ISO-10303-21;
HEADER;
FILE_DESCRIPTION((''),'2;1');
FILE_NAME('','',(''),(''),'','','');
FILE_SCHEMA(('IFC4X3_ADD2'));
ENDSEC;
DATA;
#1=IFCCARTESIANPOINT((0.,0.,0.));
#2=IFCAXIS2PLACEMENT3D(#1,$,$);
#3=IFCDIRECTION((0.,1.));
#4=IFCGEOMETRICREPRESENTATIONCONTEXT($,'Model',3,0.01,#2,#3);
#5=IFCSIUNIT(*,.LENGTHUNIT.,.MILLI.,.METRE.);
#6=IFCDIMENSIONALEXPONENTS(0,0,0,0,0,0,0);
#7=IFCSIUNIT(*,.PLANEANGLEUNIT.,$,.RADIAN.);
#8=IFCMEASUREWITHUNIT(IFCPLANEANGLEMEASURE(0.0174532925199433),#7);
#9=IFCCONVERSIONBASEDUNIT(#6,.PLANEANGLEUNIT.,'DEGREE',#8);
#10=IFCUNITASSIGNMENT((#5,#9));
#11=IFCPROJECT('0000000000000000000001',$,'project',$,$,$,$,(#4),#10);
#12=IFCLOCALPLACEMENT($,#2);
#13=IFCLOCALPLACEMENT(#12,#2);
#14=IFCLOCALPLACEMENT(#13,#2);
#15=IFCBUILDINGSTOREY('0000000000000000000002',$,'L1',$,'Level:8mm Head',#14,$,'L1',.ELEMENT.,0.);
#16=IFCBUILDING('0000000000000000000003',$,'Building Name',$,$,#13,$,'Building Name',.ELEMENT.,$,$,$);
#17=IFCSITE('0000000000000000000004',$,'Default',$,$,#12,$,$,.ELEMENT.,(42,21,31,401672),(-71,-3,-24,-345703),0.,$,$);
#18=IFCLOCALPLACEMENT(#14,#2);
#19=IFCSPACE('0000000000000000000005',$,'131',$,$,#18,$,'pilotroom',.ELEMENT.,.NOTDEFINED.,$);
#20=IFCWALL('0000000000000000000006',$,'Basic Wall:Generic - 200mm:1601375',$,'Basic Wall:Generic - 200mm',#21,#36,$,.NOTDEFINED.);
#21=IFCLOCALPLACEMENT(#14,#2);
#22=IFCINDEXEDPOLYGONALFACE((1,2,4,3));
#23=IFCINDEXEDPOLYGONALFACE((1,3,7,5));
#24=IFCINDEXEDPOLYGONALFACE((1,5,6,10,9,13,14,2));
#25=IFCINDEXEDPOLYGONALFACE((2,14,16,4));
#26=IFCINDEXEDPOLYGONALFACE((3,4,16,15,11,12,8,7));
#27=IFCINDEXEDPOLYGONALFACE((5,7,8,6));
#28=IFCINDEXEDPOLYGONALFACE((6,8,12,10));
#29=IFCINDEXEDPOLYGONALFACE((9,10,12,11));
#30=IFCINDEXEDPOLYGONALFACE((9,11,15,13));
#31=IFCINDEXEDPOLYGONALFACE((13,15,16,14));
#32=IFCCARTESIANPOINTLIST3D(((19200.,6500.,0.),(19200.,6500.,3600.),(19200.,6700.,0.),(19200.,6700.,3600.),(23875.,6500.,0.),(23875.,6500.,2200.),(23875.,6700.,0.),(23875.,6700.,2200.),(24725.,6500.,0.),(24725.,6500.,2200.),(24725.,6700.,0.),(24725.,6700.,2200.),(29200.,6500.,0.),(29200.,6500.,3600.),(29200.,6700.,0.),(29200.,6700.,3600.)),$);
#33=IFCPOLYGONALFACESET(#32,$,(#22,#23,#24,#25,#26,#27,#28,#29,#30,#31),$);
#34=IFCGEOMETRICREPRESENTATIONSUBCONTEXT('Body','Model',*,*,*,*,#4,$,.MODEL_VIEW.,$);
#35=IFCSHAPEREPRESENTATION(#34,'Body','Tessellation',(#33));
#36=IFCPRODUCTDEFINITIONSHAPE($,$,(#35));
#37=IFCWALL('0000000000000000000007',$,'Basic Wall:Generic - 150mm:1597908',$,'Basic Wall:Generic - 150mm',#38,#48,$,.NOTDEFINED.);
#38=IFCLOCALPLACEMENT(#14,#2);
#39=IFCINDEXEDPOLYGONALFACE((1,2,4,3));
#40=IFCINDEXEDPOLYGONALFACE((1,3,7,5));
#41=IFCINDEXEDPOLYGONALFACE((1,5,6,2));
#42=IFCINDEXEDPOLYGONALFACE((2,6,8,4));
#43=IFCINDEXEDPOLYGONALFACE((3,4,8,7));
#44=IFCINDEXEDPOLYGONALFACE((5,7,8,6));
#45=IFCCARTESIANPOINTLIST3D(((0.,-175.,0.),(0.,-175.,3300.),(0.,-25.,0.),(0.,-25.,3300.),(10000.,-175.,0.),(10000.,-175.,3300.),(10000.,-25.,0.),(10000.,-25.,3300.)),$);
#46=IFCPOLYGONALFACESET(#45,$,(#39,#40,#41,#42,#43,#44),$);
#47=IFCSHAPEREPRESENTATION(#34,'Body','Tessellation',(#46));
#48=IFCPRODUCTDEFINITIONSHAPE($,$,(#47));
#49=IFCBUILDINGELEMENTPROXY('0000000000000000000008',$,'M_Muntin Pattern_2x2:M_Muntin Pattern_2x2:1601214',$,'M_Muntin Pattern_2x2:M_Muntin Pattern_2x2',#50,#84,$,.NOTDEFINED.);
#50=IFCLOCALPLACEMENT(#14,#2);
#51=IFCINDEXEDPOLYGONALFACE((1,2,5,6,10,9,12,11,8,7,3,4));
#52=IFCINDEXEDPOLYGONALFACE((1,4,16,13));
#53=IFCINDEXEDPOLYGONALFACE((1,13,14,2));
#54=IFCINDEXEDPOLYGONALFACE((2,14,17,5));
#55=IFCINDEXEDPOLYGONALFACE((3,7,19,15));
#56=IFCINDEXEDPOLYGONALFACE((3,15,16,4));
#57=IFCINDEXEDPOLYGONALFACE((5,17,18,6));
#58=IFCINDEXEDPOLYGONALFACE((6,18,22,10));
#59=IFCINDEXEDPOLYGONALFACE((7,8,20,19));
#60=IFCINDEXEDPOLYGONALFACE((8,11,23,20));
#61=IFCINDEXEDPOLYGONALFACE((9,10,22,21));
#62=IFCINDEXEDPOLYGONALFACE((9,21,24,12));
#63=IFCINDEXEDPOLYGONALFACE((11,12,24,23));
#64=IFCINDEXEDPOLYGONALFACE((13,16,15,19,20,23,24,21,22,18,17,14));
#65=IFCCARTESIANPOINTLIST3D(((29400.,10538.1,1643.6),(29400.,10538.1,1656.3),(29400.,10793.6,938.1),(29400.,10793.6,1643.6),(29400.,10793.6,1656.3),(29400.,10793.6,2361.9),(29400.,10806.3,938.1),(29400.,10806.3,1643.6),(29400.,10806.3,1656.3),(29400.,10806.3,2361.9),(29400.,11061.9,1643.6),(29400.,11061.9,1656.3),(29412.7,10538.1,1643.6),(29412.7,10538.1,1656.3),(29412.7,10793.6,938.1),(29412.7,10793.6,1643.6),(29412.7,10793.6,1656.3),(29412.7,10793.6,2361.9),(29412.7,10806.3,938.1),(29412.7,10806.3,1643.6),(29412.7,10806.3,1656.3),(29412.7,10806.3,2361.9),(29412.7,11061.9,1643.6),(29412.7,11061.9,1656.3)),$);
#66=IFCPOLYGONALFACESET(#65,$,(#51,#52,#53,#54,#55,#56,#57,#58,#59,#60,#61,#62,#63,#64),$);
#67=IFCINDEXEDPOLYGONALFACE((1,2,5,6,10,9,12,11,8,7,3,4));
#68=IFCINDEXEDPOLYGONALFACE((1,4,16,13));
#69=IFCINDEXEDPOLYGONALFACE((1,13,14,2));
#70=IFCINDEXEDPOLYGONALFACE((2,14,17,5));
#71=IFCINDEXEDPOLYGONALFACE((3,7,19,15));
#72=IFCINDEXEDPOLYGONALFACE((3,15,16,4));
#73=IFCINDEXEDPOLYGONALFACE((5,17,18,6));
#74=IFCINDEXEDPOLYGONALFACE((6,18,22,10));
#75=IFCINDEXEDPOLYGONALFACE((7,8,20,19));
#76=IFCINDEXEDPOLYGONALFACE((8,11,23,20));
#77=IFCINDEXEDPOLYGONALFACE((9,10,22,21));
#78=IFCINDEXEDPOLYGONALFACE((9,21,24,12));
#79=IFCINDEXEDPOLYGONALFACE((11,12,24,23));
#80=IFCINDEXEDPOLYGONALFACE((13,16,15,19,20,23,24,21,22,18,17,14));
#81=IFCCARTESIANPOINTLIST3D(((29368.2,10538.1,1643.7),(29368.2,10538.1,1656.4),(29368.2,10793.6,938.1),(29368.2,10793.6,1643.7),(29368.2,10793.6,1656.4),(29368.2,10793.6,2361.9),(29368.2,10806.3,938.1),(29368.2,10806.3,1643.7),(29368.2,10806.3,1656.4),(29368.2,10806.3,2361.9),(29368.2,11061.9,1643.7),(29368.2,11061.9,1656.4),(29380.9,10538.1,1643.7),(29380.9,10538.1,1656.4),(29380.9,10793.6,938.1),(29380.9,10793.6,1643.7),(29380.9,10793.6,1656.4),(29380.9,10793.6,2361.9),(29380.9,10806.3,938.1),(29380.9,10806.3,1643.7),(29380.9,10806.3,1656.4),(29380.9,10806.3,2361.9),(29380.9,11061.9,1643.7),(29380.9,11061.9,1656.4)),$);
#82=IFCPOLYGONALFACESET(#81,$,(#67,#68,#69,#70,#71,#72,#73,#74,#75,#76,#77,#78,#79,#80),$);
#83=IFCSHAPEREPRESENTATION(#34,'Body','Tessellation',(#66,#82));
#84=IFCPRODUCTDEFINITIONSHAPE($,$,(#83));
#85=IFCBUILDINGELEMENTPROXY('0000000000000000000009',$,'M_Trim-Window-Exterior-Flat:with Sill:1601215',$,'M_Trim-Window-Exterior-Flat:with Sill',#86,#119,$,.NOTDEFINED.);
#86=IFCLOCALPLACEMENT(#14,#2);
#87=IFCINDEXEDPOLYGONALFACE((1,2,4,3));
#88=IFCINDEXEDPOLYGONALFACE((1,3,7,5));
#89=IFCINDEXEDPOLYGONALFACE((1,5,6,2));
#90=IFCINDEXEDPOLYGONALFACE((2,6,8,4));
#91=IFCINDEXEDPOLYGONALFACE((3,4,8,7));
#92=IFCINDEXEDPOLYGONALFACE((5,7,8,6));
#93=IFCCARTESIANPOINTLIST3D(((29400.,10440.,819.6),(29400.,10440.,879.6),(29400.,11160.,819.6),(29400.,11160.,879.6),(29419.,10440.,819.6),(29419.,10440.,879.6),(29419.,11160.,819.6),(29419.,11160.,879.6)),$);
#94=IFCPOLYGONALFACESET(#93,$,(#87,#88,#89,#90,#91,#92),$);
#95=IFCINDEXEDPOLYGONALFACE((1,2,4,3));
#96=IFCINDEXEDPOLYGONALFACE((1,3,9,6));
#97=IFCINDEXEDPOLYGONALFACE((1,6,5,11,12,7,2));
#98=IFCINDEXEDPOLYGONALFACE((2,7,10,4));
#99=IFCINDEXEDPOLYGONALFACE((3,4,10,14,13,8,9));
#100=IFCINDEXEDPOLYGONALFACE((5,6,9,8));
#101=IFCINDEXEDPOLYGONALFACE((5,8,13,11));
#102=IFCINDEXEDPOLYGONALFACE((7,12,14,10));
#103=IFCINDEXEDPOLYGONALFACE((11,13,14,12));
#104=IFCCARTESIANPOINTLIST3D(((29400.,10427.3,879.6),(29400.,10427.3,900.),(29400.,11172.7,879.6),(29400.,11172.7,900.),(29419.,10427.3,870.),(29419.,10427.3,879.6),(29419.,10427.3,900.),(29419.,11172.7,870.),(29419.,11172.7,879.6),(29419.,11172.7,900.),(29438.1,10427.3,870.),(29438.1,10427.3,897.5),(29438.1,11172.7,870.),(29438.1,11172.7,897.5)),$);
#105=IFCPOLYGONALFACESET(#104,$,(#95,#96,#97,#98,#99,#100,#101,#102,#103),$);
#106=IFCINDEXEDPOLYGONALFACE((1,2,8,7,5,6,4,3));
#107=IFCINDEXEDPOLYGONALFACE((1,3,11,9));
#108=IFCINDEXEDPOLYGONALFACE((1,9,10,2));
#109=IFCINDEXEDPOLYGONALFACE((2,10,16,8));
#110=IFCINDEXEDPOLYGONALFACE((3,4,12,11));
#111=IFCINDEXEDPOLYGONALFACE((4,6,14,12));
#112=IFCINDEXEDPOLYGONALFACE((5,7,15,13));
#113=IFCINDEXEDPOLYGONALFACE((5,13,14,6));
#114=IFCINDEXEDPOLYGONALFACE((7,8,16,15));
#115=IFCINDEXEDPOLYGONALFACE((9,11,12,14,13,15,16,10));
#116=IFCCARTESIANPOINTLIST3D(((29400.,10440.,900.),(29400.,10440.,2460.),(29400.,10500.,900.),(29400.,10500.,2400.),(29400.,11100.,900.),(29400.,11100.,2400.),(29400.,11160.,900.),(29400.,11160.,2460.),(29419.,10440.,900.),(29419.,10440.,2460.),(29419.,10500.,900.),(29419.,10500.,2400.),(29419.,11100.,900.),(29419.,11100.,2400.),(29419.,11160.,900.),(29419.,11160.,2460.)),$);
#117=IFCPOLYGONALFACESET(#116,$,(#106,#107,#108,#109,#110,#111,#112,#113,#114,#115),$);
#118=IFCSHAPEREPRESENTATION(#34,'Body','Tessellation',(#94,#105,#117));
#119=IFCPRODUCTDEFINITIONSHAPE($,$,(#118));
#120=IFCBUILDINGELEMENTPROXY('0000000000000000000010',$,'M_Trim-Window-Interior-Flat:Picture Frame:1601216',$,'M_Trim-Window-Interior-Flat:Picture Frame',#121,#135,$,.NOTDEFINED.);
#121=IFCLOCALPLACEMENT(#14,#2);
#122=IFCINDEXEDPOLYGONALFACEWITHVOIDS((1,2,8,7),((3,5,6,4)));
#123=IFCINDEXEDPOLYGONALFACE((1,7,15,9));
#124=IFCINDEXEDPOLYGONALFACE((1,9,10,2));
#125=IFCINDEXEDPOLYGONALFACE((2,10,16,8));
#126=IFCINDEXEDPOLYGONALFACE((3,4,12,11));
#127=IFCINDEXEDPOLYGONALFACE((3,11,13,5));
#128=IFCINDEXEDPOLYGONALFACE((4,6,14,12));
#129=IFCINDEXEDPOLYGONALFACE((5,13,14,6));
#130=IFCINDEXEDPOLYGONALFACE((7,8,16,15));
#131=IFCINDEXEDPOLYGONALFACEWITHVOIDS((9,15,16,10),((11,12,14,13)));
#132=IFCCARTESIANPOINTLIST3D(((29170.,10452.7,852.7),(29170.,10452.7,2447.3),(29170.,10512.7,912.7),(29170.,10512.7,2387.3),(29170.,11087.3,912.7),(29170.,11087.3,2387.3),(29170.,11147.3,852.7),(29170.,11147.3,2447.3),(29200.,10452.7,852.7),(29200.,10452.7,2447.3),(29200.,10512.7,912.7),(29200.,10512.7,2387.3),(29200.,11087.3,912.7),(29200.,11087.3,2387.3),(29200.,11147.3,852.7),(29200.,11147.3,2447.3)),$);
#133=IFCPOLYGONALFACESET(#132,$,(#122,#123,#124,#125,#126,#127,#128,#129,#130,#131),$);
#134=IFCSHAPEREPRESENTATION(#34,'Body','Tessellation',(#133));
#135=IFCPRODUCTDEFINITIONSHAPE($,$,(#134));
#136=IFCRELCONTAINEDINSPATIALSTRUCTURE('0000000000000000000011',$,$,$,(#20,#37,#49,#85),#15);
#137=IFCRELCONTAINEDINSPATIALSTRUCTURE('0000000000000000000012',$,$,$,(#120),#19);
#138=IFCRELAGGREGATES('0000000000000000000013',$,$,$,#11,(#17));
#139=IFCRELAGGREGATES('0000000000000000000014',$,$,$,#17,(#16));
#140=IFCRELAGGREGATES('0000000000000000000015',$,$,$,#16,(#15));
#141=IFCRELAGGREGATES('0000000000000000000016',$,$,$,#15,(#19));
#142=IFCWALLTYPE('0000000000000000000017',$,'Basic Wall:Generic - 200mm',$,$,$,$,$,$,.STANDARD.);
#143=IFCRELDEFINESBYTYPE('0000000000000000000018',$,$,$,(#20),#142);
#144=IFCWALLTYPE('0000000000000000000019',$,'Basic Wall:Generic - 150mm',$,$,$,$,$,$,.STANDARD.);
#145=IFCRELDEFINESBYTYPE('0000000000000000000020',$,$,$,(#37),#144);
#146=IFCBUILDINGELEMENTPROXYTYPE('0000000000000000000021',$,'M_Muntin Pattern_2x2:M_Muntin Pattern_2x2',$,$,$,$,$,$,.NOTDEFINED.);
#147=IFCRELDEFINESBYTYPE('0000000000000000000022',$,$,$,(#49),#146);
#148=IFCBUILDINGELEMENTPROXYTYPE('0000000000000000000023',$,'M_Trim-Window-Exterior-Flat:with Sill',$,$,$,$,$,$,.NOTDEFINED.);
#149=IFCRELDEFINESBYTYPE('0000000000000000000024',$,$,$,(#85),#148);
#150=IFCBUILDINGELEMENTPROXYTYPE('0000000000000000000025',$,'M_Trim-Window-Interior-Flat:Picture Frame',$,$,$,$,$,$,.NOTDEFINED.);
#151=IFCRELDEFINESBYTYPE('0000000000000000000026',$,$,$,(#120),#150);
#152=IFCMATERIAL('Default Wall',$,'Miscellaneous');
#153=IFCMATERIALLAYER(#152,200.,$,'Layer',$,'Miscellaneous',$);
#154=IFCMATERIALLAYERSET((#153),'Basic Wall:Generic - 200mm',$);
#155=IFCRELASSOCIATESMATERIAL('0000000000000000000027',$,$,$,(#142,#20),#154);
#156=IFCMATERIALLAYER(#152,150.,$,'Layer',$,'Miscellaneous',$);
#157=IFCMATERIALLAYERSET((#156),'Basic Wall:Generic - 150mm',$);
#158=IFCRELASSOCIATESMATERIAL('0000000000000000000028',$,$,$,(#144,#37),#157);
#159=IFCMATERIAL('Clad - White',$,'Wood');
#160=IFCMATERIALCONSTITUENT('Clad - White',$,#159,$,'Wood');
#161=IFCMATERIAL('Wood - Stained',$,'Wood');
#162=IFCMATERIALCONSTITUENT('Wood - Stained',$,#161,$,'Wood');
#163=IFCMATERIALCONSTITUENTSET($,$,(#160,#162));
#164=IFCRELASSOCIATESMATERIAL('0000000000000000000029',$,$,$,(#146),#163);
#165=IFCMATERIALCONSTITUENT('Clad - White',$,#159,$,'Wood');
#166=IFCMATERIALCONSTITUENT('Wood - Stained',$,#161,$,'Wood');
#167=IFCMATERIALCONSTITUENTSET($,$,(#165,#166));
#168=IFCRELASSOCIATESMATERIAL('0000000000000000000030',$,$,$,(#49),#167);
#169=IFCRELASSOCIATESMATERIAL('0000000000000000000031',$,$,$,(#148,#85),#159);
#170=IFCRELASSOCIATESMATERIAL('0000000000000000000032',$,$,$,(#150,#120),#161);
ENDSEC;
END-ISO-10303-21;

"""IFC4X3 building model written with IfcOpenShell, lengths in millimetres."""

from ifc_helpers import new_model, entity, si_unit, converted_unit, direction, frame, frame_2d, origin, place, context, subcontext, project, spatial, polyline, rectangle, outline, extrude, source, transform, mapped, material, layer, layer_set, constituent, constituent_set, type_object, type_shapes, element, save


model = new_model("IFC4X3")

# Units and contexts
model_context = context("Model", 3, precision=0.01, world=origin(), true_north=direction((0.0, 1.0)))
body_context = subcontext(model_context, "Body", "Model", "MODEL_VIEW")
ifc_project = project(units=[si_unit("LENGTHUNIT", "METRE", prefix="MILLI"), converted_unit("PLANEANGLEUNIT", "DEGREE", entity("IfcPlaneAngleMeasure", 0.0174532925199433), si_unit("PLANEANGLEUNIT", "RADIAN"), dimensions=[0, 0, 0, 0, 0, 0, 0])], contexts=[model_context])

# Site, building, storey
site_placement = place(None, origin())
site = spatial("IfcSite", under=ifc_project, at=site_placement, Name="Default", CompositionType="ELEMENT", RefLatitude=(42, 21, 31, 401672), RefLongitude=(-71, -3, -24, -345703), RefElevation=0.0)
building_placement = place(site_placement, origin())
building = spatial("IfcBuilding", under=site, at=building_placement, Name="Building Name", LongName="Building Name", CompositionType="ELEMENT")
storey_placement = place(building_placement, origin())
storey = spatial("IfcBuildingStorey", under=building, at=storey_placement, Name="L1", ObjectType="Level:8mm Head", LongName="L1", CompositionType="ELEMENT", Elevation=0.0)

# Shared definitions
ifc_material_1 = material(Name="Default Wall", Category="Miscellaneous")

# Shared definitions
ifc_layer_1 = layer(ifc_material_1, 200.0, Name="Layer", Category="Miscellaneous")
ifc_layer_set_1 = layer_set([ifc_layer_1], Name="Basic Wall:Generic - 200mm")
wall_type_1 = type_object("IfcWallType", Name="Basic Wall:Generic - 200mm", PredefinedType="STANDARD", material=ifc_layer_set_1)

# Wall, opening
wall_1_placement = place(storey_placement, frame((29200.0, 6600.0, 0.0), z_axis=(0.0, 0.0, 1.0), x_axis=(-1.0, 0.0, 0.0)))
wall_1 = element("IfcWall", 1, at=wall_1_placement, inside=storey, type_object=wall_type_1, material=ifc_layer_set_1, Name="Basic Wall:Generic - 200mm:1601375", ObjectType="Basic Wall:Generic - 200mm", PredefinedType="NOTDEFINED", context=body_context, shape_type="SweptSolid", body=[
    extrude(rectangle(XDim=10000.0, YDim=200.0, at=frame_2d((5000.0, 0.0), x_axis=(1.0, 0.0))), origin(), (0.0, 0.0, 1.0), 3600.0),
])
opening_1_placement = place(wall_1_placement, frame((5325.0, 100.0, 0.0)))
element("IfcOpeningElement", 2, at=opening_1_placement, cuts=wall_1, PredefinedType="OPENING", context=body_context, shape_type="SweptSolid", body=[
    extrude(rectangle(XDim=2200.0, YDim=850.0, at=frame_2d((1100.0, 425.0), x_axis=(1.0, 0.0))), frame((0.0, 0.0, 0.0), z_axis=(0.0, -1.0, 0.0), x_axis=(0.0, 0.0, 1.0)), (0.0, 0.0, 1.0), 200.0),
])

# Wall
ifc_layer_2 = layer(ifc_material_1, 150.0, Name="Layer", Category="Miscellaneous")
ifc_layer_set_2 = layer_set([ifc_layer_2], Name="Basic Wall:Generic - 150mm")
wall_type_2 = type_object("IfcWallType", Name="Basic Wall:Generic - 150mm", PredefinedType="STANDARD", material=ifc_layer_set_2)
wall_2_placement = place(storey_placement, frame((0.0, -100.0, 0.0)))
element("IfcWall", 3, at=wall_2_placement, inside=storey, type_object=wall_type_2, material=ifc_layer_set_2, Name="Basic Wall:Generic - 150mm:1597908", ObjectType="Basic Wall:Generic - 150mm", PredefinedType="NOTDEFINED", context=body_context, shape_type="SweptSolid", body=[
    extrude(rectangle(XDim=10000.0, YDim=150.0, at=frame_2d((5000.0, 0.0), x_axis=(-1.0, 0.0))), origin(), (0.0, 0.0, 1.0), 3300.0),
])

# Building element proxies
ifc_material_2 = material(Name="Clad - White", Category="Wood")
ifc_constituent_1 = constituent(ifc_material_2, Name="Clad - White", Category="Wood")
ifc_material_3 = material(Name="Wood - Stained", Category="Wood")
ifc_constituent_2 = constituent(ifc_material_3, Name="Wood - Stained", Category="Wood")
ifc_constituent_set_1 = constituent_set(constituents=[ifc_constituent_1, ifc_constituent_2])
ifc_constituent_3 = constituent(ifc_material_2, Name="Clad - White", Category="Wood")
ifc_constituent_4 = constituent(ifc_material_3, Name="Wood - Stained", Category="Wood")
ifc_constituent_set_2 = constituent_set(constituents=[ifc_constituent_3, ifc_constituent_4])
building_element_proxy_type_1 = type_object("IfcBuildingElementProxyType", Name="M_Muntin Pattern_2x2:M_Muntin Pattern_2x2", PredefinedType="NOTDEFINED", material=ifc_constituent_set_2)
shared_shape_1 = source(origin(), body_context, "Body", "SweptSolid", [
    extrude(outline(polyline([(6.4, -6.4), (711.9, -6.4), (711.9, 6.3), (6.4, 6.3), (6.4, 261.9), (-6.3, 261.9), (-6.3, 6.3), (-711.9, 6.3), (-711.9, -6.4), (-6.3, -6.4), (-6.3, -261.9), (6.4, -261.9), (6.4, -6.4)])), frame((0.0, -22.2, 711.9), z_axis=(0.0, 1.0, 0.0), x_axis=(0.0, 0.0, 1.0)), (0.0, 0.0, 1.0), 12.7),
    extrude(outline(polyline([(6.4, -6.4), (711.9, -6.4), (711.9, 6.3), (6.4, 6.3), (6.4, 261.9), (-6.3, 261.9), (-6.3, 6.3), (-711.9, 6.3), (-711.9, -6.4), (-6.3, -6.4), (-6.3, -261.9), (6.4, -261.9), (6.4, -6.4)])), frame((0.0, 9.5, 711.9), z_axis=(0.0, 1.0, 0.0), x_axis=(0.0, 0.0, 1.0)), (0.0, 0.0, 1.0), 12.7),
])
type_shapes(building_element_proxy_type_1, [shared_shape_1])
proxy_1_placement = place(storey_placement, frame((29390.5, 10800.0, 938.1), z_axis=(0.0, 0.0, 1.0), x_axis=(0.0, 1.0, 0.0)))
element("IfcBuildingElementProxy", 4, at=proxy_1_placement, inside=storey, type_object=building_element_proxy_type_1, material=ifc_constituent_set_1, Name="M_Muntin Pattern_2x2:M_Muntin Pattern_2x2:1601214", ObjectType="M_Muntin Pattern_2x2:M_Muntin Pattern_2x2", PredefinedType="NOTDEFINED", context=body_context, shape_type="MappedRepresentation", body=[
    mapped(shared_shape_1, transform((0.0, 0.0, 0.0), scale=1.0)),
])
building_element_proxy_type_2 = type_object("IfcBuildingElementProxyType", Name="M_Trim-Window-Exterior-Flat:with Sill", PredefinedType="NOTDEFINED", material=ifc_material_2)
shared_shape_2 = source(origin(), body_context, "Body", "SweptSolid", [
    extrude(rectangle(XDim=720.0, YDim=60.0, at=frame_2d((0.0, 0.0), x_axis=(1.0, 0.0))), frame((0.0, -1550.4, 0.0), z_axis=(0.0, 0.0, 1.0), x_axis=(-1.0, 0.0, 0.0)), (0.0, 0.0, 1.0), 19.1),
    extrude(outline(polyline([(-19.0, -15.2), (0.0, -15.2), (0.0, -5.7), (19.0, -5.7), (19.0, 14.8), (0.0, 14.8), (-19.0, 12.3), (-19.0, -15.2)])), frame((-372.7, -1514.8, 19.0), z_axis=(1.0, 0.0, 0.0), x_axis=(0.0, 0.0, -1.0)), (0.0, 0.0, 1.0), 745.4),
    extrude(outline(polyline([(-795.0, -360.0), (765.0, -360.0), (765.0, -300.0), (-735.0, -300.0), (-735.0, 300.0), (765.0, 300.0), (765.0, 360.0), (-795.0, 360.0), (-795.0, -360.0)])), frame((0.0, -735.0, 0.0), z_axis=(0.0, 0.0, 1.0), x_axis=(0.0, -1.0, 0.0)), (0.0, 0.0, 1.0), 19.1),
])
type_shapes(building_element_proxy_type_2, [shared_shape_2])
proxy_2_placement = place(storey_placement, frame((29400.0, 10800.0, 2400.0), z_axis=(1.0, 0.0, 0.0), x_axis=(0.0, 1.0, 0.0)))
element("IfcBuildingElementProxy", 5, at=proxy_2_placement, inside=storey, type_object=building_element_proxy_type_2, material=ifc_material_2, Name="M_Trim-Window-Exterior-Flat:with Sill:1601215", ObjectType="M_Trim-Window-Exterior-Flat:with Sill", PredefinedType="NOTDEFINED", context=body_context, shape_type="MappedRepresentation", body=[
    mapped(shared_shape_2, transform((0.0, 0.0, 0.0), scale=1.0)),
])

# Shared definitions
space_placement = place(storey_placement, origin())
space = spatial("IfcSpace", under=storey, at=space_placement, Name="131", LongName="pilotroom", CompositionType="ELEMENT", PredefinedType="NOTDEFINED")

# Building element proxy
building_element_proxy_type_3 = type_object("IfcBuildingElementProxyType", Name="M_Trim-Window-Interior-Flat:Picture Frame", PredefinedType="NOTDEFINED", material=ifc_material_3)
shared_shape_3 = source(origin(), body_context, "Body", "SweptSolid", [
    extrude(outline(polyline([(-347.3, -797.3), (347.3, -797.3), (347.3, 797.3), (-347.3, 797.3), (-347.3, -797.3)]), holes=[polyline([(-287.3, -737.3), (-287.3, 737.3), (287.3, 737.3), (287.3, -737.3), (-287.3, -737.3)])]), frame((0.0, -750.0, 0.0), z_axis=(0.0, 0.0, 1.0), x_axis=(-1.0, 0.0, 0.0)), (0.0, 0.0, 1.0), 30.0),
])
type_shapes(building_element_proxy_type_3, [shared_shape_3])
proxy_3_placement = place(space_placement, frame((29200.0, 10800.0, 2400.0), z_axis=(-1.0, 0.0, 0.0), x_axis=(0.0, -1.0, 0.0)))
element("IfcBuildingElementProxy", 6, at=proxy_3_placement, inside=space, type_object=building_element_proxy_type_3, material=ifc_material_3, Name="M_Trim-Window-Interior-Flat:Picture Frame:1601216", ObjectType="M_Trim-Window-Interior-Flat:Picture Frame", PredefinedType="NOTDEFINED", context=body_context, shape_type="MappedRepresentation", body=[
    mapped(shared_shape_3, transform((0.0, 0.0, 0.0), scale=1.0)),
])

save(model, "model.ifc")
